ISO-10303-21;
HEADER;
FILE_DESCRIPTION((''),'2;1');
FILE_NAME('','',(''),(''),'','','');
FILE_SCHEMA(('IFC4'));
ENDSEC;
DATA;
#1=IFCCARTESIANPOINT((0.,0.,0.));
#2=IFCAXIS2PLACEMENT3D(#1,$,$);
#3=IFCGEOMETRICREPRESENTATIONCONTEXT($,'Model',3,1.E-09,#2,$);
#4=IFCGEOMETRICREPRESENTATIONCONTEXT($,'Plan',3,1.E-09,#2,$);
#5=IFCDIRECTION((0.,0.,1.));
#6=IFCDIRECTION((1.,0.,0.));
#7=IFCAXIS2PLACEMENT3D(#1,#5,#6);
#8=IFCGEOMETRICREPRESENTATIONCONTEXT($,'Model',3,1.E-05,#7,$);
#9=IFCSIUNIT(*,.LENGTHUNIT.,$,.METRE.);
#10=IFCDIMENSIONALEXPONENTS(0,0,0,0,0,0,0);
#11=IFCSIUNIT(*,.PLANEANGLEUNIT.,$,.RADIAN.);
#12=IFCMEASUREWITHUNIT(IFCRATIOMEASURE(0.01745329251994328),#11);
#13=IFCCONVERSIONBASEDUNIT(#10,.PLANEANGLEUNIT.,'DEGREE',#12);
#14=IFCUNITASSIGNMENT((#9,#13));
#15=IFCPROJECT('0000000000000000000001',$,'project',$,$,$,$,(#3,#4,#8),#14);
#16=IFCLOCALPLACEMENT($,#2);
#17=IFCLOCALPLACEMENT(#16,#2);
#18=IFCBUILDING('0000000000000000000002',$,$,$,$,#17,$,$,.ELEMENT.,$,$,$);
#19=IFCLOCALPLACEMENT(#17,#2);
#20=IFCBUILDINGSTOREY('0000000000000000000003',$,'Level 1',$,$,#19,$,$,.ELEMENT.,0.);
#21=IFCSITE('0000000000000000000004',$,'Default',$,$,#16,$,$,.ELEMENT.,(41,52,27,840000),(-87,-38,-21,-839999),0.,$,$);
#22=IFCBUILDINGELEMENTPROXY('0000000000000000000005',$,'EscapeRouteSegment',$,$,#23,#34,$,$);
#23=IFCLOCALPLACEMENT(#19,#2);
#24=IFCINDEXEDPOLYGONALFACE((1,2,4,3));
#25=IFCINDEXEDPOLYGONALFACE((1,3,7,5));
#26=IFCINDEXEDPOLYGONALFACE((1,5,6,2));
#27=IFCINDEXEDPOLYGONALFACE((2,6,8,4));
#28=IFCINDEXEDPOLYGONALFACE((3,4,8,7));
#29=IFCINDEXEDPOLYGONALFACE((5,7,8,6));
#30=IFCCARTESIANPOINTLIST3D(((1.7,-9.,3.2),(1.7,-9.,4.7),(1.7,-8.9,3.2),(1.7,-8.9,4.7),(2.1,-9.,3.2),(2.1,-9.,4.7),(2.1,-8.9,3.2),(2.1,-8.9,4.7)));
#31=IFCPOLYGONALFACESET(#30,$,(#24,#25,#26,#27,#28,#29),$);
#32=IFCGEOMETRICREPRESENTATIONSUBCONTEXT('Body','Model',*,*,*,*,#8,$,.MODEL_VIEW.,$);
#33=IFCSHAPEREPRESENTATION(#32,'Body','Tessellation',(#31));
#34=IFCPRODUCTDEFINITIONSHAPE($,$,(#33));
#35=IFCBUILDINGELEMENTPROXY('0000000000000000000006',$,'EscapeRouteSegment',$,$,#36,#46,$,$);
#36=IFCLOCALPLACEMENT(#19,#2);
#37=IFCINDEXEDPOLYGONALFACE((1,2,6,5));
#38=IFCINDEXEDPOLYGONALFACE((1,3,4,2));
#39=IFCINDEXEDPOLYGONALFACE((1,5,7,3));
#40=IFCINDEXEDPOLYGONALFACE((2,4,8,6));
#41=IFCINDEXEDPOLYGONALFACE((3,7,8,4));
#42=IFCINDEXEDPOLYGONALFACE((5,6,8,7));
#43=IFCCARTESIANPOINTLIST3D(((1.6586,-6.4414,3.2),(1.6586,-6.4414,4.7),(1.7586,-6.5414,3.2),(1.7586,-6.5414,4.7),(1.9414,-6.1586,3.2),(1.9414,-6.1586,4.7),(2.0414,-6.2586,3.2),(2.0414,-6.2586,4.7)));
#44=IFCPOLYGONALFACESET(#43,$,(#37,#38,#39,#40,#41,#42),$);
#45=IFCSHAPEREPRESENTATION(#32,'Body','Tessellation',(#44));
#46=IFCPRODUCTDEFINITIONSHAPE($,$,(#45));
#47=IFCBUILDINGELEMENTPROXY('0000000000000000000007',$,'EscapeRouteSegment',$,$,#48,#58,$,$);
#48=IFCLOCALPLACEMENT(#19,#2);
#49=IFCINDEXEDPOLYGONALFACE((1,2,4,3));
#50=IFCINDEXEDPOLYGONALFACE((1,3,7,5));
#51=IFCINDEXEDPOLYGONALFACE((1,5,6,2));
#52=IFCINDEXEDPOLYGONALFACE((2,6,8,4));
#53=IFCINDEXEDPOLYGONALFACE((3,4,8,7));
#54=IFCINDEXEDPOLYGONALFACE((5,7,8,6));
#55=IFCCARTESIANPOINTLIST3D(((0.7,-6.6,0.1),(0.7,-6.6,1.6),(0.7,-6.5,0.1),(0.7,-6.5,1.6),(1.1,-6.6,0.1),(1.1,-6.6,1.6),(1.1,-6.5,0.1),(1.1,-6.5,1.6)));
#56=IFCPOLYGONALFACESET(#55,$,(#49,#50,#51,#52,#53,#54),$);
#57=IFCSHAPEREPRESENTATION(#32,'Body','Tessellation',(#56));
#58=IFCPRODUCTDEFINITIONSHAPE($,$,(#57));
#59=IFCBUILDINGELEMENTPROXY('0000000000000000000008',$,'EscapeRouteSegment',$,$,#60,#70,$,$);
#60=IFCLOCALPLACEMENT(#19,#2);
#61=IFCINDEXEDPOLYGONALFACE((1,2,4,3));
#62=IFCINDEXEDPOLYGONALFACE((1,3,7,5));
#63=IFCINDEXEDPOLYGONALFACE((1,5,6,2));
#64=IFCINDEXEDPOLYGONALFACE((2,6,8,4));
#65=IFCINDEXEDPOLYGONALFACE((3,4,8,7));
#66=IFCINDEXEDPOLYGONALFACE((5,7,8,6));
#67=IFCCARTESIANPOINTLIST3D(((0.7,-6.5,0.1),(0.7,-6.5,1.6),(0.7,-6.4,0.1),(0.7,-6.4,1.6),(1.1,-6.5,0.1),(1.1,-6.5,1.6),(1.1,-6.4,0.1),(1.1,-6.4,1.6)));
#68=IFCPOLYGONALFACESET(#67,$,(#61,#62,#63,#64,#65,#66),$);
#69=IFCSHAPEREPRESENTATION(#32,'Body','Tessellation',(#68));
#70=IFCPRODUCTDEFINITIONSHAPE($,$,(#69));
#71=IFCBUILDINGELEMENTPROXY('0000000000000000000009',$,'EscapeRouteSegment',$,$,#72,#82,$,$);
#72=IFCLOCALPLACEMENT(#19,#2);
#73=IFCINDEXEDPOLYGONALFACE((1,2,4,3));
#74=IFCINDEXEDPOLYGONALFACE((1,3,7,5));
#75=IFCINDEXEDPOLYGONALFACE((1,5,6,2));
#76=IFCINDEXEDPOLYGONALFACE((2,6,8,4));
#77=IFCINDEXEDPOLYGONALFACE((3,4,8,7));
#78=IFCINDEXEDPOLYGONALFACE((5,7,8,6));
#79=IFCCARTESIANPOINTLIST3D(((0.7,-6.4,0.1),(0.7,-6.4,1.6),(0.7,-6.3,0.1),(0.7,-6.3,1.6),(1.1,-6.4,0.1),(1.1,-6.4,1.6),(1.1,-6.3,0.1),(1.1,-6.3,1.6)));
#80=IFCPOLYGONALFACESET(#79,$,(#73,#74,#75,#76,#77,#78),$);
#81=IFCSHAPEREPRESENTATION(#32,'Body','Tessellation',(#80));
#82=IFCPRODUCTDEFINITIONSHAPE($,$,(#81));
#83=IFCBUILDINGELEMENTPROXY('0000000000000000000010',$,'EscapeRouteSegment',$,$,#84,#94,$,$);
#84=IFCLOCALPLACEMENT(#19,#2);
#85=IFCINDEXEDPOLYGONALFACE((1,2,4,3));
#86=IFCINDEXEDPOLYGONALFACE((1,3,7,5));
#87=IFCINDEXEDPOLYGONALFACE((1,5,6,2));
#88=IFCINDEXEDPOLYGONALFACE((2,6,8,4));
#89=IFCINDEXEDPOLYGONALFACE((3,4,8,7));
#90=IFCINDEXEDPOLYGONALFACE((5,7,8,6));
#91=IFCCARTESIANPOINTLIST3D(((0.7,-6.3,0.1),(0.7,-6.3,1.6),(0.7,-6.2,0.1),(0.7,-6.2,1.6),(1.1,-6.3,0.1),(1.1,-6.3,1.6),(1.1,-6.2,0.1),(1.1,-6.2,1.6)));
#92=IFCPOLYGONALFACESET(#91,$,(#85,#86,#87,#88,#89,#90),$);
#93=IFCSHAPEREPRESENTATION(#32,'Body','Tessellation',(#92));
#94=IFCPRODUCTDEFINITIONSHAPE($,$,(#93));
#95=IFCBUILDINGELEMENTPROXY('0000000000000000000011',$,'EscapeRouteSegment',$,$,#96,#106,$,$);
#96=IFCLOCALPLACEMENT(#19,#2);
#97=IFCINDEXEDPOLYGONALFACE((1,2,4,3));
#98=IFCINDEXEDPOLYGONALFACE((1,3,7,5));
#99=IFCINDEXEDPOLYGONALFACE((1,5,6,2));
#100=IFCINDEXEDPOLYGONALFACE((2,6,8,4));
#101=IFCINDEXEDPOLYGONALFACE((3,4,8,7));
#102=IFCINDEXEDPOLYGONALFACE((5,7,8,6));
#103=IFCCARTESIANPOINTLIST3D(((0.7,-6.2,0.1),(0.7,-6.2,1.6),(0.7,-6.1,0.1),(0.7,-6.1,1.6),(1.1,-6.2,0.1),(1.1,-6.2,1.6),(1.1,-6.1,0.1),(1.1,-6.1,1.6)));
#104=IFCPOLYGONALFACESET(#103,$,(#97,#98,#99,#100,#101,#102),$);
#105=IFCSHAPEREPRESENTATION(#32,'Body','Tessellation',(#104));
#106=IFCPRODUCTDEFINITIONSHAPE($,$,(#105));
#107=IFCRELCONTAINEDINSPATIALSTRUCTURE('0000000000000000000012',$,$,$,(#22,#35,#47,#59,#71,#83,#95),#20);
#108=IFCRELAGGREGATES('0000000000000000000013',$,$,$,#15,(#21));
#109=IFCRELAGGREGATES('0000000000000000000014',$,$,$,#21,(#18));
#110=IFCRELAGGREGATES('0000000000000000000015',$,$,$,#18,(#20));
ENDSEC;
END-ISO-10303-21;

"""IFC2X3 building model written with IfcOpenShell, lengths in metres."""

from ifc_helpers import new_model, entity, si_unit, converted_unit, frame, origin, origin_with_axes, place, context, subcontext, project, spatial, polyline, outline, extrude, element, save


model = new_model("IFC2X3")

# Units and contexts
model_context_1 = context("Model", 3, precision=1e-09, world=origin())
plan_context = context("Plan", 3, precision=1e-09, world=origin())
model_context_2 = context("Model", 3, precision=1e-05, world=origin_with_axes())
body_context = subcontext(model_context_2, "Body", "Model", "MODEL_VIEW")
ifc_project = project(units=[si_unit("LENGTHUNIT", "METRE"), converted_unit("PLANEANGLEUNIT", "DEGREE", entity("IfcRatioMeasure", 0.01745329251994328), si_unit("PLANEANGLEUNIT", "RADIAN"), dimensions=[0, 0, 0, 0, 0, 0, 0])], contexts=[model_context_1, plan_context, model_context_2])

# Site, building, storey
site_placement = place(None, origin())
site = spatial("IfcSite", under=ifc_project, at=site_placement, Name="Default", CompositionType="ELEMENT", RefLatitude=(41, 52, 27, 840000), RefLongitude=(-87, -38, -21, -839999), RefElevation=0.0)
building_placement = place(site_placement, origin())
building = spatial("IfcBuilding", under=site, at=building_placement, CompositionType="ELEMENT")
storey_placement = place(building_placement, origin())
storey = spatial("IfcBuildingStorey", under=building, at=storey_placement, Name="Level 1", CompositionType="ELEMENT", Elevation=0.0)

# Building element proxies
proxy_1_placement = place(storey_placement, frame((1.9, -8.9, 3.2), z_axis=(0.0, 0.0, 1.0), x_axis=(0.0, -1.0, 0.0)))
element("IfcBuildingElementProxy", 1, at=proxy_1_placement, inside=storey, Name="EscapeRouteSegment", context=body_context, shape_type="SweptSolid", body=[
    extrude(outline(polyline([(0.0, -0.2), (0.0, 0.2), (0.1, 0.2), (0.1, -0.2), (0.0, -0.2)])), origin_with_axes(), (0.0, 0.0, 1.0), 1.5),
])
proxy_2_placement = place(storey_placement, frame((1.8, -6.3, 3.2), z_axis=(0.0, 0.0, 1.0), x_axis=(0.707107, -0.707106, 0.0)))
element("IfcBuildingElementProxy", 2, at=proxy_2_placement, inside=storey, Name="EscapeRouteSegment", context=body_context, shape_type="SweptSolid", body=[
    extrude(outline(polyline([(0.0, -0.2), (0.0, 0.2), (0.1414, 0.2), (0.1414, -0.2), (0.0, -0.2)])), origin_with_axes(), (0.0, 0.0, 1.0), 1.5),
])
for number, where, z_axis, x_axis, name in (
    (3, (0.9, -6.6, 0.1), (0.0, 0.0, 1.0), (0.0, 1.0, 0.0), "EscapeRouteSegment"),
    (4, (0.9, -6.5, 0.1), (0.0, 0.0, 1.0), (0.0, 1.0, 0.0), "EscapeRouteSegment"),
    (5, (0.9, -6.4, 0.1), (0.0, 0.0, 1.0), (0.0, 1.0, 0.0), "EscapeRouteSegment"),
):
    element("IfcBuildingElementProxy", number, at=place(storey_placement, frame(where, z_axis=z_axis, x_axis=x_axis)), inside=storey, Name=name, context=body_context, shape_type="SweptSolid", body=[
        extrude(outline(polyline([(0.0, -0.2), (0.0, 0.2), (0.1, 0.2), (0.1, -0.2), (0.0, -0.2)])), origin_with_axes(), (0.0, 0.0, 1.0), 1.5),
    ])
proxy_3_placement = place(storey_placement, frame((0.9, -6.3, 0.1), z_axis=(0.0, 0.0, 1.0), x_axis=(0.0, 1.0, 0.0)))
element("IfcBuildingElementProxy", 6, at=proxy_3_placement, inside=storey, Name="EscapeRouteSegment", context=body_context, shape_type="SweptSolid", body=[
    extrude(outline(polyline([(0.0, -0.2), (0.0, 0.2), (0.1, 0.2), (0.1, -0.2), (0.0, -0.2)])), origin_with_axes(), (0.0, 0.0, 1.0), 1.5),
])
proxy_4_placement = place(storey_placement, frame((0.9, -6.2, 0.1), z_axis=(0.0, 0.0, 1.0), x_axis=(0.0, 1.0, 0.0)))
element("IfcBuildingElementProxy", 7, at=proxy_4_placement, inside=storey, Name="EscapeRouteSegment", context=body_context, shape_type="SweptSolid", body=[
    extrude(outline(polyline([(0.0, -0.2), (0.0, 0.2), (0.1, 0.2), (0.1, -0.2), (0.0, -0.2)])), origin_with_axes(), (0.0, 0.0, 1.0), 1.5),
])

save(model, "model.ifc")
